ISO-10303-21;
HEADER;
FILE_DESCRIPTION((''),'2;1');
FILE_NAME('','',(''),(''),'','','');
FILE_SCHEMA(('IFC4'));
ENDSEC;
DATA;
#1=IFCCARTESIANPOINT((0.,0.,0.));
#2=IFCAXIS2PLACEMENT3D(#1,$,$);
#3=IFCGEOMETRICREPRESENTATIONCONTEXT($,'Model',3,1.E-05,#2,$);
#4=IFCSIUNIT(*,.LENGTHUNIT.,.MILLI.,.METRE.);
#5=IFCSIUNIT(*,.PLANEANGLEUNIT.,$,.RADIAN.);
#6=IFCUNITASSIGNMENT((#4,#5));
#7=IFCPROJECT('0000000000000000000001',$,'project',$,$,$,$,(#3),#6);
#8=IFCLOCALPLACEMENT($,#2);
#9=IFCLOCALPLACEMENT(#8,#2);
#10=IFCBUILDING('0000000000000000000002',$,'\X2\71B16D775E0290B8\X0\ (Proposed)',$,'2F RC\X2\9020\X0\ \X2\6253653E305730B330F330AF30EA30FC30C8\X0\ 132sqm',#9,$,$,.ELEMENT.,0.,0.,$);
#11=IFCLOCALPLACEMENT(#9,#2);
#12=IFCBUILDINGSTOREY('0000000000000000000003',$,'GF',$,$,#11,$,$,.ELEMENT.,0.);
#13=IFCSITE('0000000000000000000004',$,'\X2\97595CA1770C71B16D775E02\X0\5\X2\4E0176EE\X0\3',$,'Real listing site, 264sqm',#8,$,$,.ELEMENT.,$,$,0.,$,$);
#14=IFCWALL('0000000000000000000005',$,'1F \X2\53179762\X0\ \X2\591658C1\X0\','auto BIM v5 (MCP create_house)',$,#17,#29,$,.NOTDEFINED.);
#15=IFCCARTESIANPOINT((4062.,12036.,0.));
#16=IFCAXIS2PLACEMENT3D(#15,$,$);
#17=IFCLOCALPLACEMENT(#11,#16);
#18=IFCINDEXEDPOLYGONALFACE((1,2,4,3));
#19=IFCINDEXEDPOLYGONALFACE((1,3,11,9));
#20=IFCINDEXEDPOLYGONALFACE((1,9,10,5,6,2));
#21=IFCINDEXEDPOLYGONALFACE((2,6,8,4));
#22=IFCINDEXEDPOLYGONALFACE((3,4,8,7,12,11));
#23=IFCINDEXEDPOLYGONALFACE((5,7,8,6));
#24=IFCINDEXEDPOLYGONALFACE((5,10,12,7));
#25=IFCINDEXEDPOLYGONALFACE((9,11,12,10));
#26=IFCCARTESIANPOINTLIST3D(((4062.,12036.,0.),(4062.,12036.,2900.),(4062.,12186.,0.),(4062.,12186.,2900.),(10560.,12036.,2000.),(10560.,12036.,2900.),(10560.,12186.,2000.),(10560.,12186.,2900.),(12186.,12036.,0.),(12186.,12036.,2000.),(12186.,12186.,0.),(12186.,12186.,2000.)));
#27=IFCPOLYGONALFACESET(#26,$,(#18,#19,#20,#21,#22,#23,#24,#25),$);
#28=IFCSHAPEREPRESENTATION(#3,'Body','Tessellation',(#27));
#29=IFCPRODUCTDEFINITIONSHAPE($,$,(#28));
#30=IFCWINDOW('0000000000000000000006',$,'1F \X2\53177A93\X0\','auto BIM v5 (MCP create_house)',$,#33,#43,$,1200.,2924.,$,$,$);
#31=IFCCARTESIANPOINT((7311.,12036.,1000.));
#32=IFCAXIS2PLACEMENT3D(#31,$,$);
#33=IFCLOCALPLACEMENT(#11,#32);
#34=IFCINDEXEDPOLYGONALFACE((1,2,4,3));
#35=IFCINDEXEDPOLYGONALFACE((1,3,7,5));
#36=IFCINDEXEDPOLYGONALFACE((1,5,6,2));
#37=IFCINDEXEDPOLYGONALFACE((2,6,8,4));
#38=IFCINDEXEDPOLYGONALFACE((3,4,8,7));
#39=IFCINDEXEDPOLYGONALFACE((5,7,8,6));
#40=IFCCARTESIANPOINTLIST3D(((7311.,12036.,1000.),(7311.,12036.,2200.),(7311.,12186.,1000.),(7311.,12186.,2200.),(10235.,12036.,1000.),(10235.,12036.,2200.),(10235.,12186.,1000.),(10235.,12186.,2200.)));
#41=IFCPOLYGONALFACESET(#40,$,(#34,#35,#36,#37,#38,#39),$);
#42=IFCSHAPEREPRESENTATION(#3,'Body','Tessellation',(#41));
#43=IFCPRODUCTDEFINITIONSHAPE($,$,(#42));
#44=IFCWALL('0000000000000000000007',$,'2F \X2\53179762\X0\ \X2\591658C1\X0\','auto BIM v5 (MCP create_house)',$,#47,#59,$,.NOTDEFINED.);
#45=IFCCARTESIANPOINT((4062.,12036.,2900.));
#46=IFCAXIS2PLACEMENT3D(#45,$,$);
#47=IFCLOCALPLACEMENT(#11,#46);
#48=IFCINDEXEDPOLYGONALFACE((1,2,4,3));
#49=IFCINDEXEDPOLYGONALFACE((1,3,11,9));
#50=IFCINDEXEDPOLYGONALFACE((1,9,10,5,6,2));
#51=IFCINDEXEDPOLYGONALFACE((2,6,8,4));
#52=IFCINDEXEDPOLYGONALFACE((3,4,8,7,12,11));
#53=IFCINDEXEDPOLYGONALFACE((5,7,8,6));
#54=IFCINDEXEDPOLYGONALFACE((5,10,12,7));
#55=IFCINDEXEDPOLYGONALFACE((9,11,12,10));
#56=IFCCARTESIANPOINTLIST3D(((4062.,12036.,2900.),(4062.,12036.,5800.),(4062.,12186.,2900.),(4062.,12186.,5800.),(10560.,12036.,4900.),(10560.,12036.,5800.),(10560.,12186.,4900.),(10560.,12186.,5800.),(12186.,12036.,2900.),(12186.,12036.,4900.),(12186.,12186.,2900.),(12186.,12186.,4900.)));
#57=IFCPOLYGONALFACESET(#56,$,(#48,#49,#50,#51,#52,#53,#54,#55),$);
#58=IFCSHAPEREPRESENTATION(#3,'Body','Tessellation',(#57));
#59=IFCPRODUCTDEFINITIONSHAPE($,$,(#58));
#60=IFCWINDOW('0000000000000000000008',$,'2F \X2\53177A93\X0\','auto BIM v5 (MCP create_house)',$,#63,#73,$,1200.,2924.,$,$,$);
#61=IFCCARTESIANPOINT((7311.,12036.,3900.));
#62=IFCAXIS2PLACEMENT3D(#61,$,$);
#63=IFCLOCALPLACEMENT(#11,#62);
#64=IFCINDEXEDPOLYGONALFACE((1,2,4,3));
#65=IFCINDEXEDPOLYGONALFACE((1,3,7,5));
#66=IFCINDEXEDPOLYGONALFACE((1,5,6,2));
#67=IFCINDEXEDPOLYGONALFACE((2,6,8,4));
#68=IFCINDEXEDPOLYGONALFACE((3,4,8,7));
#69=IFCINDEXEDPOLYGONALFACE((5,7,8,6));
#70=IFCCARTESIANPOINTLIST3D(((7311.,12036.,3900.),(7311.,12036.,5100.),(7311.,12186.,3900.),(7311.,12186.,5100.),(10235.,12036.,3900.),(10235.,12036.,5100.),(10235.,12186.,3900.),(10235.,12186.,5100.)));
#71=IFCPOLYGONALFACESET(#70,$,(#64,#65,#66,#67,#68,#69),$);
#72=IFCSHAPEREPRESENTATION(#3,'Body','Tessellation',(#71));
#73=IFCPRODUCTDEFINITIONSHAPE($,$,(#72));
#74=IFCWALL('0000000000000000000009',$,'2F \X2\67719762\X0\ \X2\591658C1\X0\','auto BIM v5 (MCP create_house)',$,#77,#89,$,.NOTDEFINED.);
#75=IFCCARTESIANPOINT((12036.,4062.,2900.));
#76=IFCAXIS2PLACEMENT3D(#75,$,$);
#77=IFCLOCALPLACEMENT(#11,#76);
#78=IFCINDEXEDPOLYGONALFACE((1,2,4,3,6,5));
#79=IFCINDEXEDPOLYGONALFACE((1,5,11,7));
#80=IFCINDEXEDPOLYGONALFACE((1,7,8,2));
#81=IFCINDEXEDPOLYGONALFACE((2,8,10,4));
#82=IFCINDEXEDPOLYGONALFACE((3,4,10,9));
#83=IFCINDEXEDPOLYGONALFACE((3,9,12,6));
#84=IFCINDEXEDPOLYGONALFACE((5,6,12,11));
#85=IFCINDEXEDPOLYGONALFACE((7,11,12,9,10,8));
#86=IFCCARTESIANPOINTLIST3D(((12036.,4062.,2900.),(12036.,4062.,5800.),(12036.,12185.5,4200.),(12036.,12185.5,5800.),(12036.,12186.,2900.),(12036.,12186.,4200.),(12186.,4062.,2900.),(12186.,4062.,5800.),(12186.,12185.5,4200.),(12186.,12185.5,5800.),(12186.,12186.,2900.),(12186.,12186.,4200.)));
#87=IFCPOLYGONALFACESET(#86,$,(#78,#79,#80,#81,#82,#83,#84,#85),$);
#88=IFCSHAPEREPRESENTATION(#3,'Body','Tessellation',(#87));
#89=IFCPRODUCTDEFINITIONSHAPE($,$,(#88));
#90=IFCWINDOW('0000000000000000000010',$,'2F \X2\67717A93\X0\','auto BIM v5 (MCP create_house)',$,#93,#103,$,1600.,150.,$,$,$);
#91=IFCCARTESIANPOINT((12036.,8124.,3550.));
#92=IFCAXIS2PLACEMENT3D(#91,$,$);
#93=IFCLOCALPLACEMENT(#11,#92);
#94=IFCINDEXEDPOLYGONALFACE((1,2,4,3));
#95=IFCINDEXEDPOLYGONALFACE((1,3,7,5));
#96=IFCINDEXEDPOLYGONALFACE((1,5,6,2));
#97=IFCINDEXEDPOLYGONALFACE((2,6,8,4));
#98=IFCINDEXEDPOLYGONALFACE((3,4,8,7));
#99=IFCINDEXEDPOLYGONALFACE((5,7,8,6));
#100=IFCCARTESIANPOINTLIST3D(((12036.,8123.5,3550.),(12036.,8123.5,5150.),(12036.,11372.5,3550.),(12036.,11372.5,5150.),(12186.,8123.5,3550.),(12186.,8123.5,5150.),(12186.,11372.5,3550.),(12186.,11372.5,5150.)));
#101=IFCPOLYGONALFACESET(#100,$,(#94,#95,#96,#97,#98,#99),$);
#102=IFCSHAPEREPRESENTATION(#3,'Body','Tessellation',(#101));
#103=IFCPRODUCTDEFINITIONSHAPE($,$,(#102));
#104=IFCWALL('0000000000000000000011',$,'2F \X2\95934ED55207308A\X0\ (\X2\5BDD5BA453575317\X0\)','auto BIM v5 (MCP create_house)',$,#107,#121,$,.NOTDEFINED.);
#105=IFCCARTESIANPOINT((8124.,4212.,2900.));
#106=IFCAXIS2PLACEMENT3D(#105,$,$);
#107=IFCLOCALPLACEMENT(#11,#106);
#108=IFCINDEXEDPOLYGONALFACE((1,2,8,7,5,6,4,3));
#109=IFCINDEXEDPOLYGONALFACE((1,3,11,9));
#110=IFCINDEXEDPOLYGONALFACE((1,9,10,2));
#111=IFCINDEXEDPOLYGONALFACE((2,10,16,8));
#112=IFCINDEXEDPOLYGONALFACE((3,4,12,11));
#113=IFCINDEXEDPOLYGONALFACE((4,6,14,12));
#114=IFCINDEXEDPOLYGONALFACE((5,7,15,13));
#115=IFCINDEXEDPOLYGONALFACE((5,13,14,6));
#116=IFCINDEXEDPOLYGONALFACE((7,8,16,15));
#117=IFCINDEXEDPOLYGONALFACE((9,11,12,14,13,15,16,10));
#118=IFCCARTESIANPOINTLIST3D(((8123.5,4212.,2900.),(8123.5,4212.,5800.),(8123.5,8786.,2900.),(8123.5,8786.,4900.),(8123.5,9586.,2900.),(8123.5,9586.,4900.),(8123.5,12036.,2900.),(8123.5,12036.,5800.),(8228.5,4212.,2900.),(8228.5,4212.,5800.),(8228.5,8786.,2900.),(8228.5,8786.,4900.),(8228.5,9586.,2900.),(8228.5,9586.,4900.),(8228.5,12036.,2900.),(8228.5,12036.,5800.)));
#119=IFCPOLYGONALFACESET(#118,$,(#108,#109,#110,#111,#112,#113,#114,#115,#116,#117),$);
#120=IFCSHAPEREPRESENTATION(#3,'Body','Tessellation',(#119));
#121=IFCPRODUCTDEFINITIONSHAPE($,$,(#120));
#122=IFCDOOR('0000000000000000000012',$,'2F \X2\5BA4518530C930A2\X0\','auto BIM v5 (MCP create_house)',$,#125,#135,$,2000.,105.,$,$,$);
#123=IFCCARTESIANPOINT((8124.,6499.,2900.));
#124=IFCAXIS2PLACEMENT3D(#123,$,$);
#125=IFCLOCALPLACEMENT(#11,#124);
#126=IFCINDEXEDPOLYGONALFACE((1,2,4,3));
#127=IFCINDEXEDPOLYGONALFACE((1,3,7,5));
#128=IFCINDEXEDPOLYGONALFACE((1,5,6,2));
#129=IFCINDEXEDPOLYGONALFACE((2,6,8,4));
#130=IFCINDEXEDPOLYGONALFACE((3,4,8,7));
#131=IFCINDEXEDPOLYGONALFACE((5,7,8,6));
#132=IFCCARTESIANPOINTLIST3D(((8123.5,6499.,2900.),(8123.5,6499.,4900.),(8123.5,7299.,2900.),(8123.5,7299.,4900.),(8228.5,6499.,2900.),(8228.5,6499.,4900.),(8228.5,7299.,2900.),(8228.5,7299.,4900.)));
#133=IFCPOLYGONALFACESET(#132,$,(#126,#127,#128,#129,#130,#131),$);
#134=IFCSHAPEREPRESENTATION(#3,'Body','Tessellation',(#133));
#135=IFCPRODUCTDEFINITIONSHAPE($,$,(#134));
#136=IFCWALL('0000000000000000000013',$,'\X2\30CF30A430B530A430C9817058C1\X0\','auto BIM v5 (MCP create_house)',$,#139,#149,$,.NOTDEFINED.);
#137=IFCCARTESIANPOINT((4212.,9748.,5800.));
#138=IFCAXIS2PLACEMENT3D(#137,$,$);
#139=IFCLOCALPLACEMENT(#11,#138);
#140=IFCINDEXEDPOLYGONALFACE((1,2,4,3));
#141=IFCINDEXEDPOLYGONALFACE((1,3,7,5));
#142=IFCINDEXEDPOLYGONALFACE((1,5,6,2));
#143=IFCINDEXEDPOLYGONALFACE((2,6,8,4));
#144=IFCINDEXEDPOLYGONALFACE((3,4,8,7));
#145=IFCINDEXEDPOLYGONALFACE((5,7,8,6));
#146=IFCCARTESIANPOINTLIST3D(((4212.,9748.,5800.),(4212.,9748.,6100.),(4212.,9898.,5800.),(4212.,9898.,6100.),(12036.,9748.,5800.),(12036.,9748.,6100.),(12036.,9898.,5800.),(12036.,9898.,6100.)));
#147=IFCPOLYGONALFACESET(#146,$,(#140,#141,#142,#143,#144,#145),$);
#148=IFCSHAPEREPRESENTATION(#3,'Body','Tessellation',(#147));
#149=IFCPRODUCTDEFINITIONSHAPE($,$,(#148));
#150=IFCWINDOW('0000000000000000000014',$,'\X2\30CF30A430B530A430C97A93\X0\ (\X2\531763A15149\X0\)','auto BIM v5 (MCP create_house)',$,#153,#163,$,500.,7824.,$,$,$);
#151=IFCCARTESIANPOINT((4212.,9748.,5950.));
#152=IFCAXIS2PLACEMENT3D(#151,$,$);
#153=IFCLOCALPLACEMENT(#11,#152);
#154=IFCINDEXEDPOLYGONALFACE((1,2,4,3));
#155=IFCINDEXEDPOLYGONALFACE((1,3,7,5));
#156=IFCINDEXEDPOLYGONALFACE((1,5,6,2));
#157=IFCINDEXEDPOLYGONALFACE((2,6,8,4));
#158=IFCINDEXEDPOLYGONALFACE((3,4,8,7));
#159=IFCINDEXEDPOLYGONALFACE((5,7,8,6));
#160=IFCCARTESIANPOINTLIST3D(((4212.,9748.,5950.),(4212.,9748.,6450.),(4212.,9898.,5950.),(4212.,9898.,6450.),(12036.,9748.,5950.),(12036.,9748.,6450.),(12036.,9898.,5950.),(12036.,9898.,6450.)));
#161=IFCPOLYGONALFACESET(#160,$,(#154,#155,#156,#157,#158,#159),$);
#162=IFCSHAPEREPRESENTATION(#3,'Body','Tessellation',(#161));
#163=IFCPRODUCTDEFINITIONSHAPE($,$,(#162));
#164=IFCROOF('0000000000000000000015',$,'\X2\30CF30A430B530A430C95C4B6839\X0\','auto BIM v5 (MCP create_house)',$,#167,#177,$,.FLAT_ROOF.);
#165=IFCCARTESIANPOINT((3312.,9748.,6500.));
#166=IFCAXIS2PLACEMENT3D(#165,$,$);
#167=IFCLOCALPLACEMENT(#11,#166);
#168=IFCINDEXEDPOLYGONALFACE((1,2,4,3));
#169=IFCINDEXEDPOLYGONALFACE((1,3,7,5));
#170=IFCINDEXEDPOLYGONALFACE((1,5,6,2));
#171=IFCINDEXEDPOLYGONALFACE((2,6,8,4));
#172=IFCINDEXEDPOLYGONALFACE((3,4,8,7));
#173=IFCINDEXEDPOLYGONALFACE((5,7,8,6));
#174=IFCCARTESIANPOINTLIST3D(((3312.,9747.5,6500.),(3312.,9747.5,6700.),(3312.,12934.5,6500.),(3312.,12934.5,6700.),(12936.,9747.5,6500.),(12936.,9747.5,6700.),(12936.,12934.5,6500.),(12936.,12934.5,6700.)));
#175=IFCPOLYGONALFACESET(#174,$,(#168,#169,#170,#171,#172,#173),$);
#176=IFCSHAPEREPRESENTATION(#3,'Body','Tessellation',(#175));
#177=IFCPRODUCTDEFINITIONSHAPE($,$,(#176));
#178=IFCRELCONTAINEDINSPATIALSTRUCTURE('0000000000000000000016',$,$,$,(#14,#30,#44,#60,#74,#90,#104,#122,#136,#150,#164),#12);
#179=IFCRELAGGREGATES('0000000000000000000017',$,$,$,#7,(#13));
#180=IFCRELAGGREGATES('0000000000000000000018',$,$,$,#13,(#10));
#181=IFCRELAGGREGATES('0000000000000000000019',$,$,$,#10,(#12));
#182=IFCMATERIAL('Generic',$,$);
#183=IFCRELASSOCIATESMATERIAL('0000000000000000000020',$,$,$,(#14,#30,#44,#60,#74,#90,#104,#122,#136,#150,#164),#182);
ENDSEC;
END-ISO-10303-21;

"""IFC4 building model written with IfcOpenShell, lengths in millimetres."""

from ifc_helpers import new_model, si_unit, frame, frame_2d, origin, place, context, project, spatial, rectangle, extrude, material, element, fill, save


model = new_model("IFC4")

# Units and contexts
model_context = context("Model", 3, precision=1e-05, world=origin())
ifc_project = project(units=[si_unit("LENGTHUNIT", "METRE", prefix="MILLI"), si_unit("PLANEANGLEUNIT", "RADIAN")], contexts=[model_context])

# Site, building, storey
site_placement = place(None, origin())
site = spatial("IfcSite", under=ifc_project, at=site_placement, Name="静岡県熱海市5丁目3", ObjectType="Real listing site, 264sqm", CompositionType="ELEMENT", RefElevation=0.0)
building_placement = place(site_placement, origin())
building = spatial("IfcBuilding", under=site, at=building_placement, Name="熱海市邸 (Proposed)", ObjectType="2F RC造 打放しコンクリート 132sqm", CompositionType="ELEMENT", ElevationOfRefHeight=0.0, ElevationOfTerrain=0.0)
storey_placement = place(building_placement, origin())
storey = spatial("IfcBuildingStorey", under=building, at=storey_placement, Name="GF", CompositionType="ELEMENT", Elevation=0.0)

# Wall, opening, window
ifc_material = material(Name="Generic")
wall_1_placement = place(storey_placement, frame((4062.0, 12036.0, 0.0)))
wall_1 = element("IfcWall", 1, at=wall_1_placement, inside=storey, material=ifc_material, Name="1F 北面 外壁", Description="auto BIM v5 (MCP create_house)", PredefinedType="NOTDEFINED", context=model_context, shape_type="SweptSolid", body=[
    extrude(rectangle(XDim=8124.0, YDim=150.0, at=frame_2d((4062.0, 75.0))), frame((4062.0, 12036.0, 0.0)), (0.0, 0.0, 1.0), 2900.0),
])
opening_1_placement = place(storey_placement, frame((7311.0, 12036.0, 1000.0)))
opening_1 = element("IfcOpeningElement", 2, at=opening_1_placement, cuts=wall_1, PredefinedType="NOTDEFINED", context=model_context, shape_type="SweptSolid", body=[
    extrude(rectangle(XDim=2924.0, YDim=150.0, at=frame_2d((1462.0, 75.0))), frame((7311.0, 12036.0, 1000.0)), (0.0, 0.0, 1.0), 1200.0),
])
window_1_placement = place(storey_placement, frame((7311.0, 12036.0, 1000.0)))
window_1 = element("IfcWindow", 3, at=window_1_placement, inside=storey, material=ifc_material, Name="1F 北窓", Description="auto BIM v5 (MCP create_house)", OverallHeight=1200.0, OverallWidth=2924.0, context=model_context, shape_type="SweptSolid", body=[
    extrude(rectangle(XDim=2924.0, YDim=150.0, at=frame_2d((1462.0, 75.0))), frame((7311.0, 12036.0, 1000.0)), (0.0, 0.0, 1.0), 1200.0),
])
fill(opening_1, window_1)

# Walls, openings, windows
wall_2_placement = place(storey_placement, frame((4062.0, 12036.0, 2900.0)))
wall_2 = element("IfcWall", 4, at=wall_2_placement, inside=storey, material=ifc_material, Name="2F 北面 外壁", Description="auto BIM v5 (MCP create_house)", PredefinedType="NOTDEFINED", context=model_context, shape_type="SweptSolid", body=[
    extrude(rectangle(XDim=8124.0, YDim=150.0, at=frame_2d((4062.0, 75.0))), frame((4062.0, 12036.0, 2900.0)), (0.0, 0.0, 1.0), 2900.0),
])
opening_2_placement = place(storey_placement, frame((7311.0, 12036.0, 3900.0)))
opening_2 = element("IfcOpeningElement", 5, at=opening_2_placement, cuts=wall_2, PredefinedType="NOTDEFINED", context=model_context, shape_type="SweptSolid", body=[
    extrude(rectangle(XDim=2924.0, YDim=150.0, at=frame_2d((1462.0, 75.0))), frame((7311.0, 12036.0, 3900.0)), (0.0, 0.0, 1.0), 1200.0),
])
window_2_placement = place(storey_placement, frame((7311.0, 12036.0, 3900.0)))
window_2 = element("IfcWindow", 6, at=window_2_placement, inside=storey, material=ifc_material, Name="2F 北窓", Description="auto BIM v5 (MCP create_house)", OverallHeight=1200.0, OverallWidth=2924.0, context=model_context, shape_type="SweptSolid", body=[
    extrude(rectangle(XDim=2924.0, YDim=150.0, at=frame_2d((1462.0, 75.0))), frame((7311.0, 12036.0, 3900.0)), (0.0, 0.0, 1.0), 1200.0),
])
fill(opening_2, window_2)
wall_3_placement = place(storey_placement, frame((12036.0, 4062.0, 2900.0)))
wall_3 = element("IfcWall", 7, at=wall_3_placement, inside=storey, material=ifc_material, Name="2F 東面 外壁", Description="auto BIM v5 (MCP create_house)", PredefinedType="NOTDEFINED", context=model_context, shape_type="SweptSolid", body=[
    extrude(rectangle(XDim=150.0, YDim=8124.0, at=frame_2d((75.0, 4062.0))), frame((12036.0, 4062.0, 2900.0)), (0.0, 0.0, 1.0), 2900.0),
])
opening_3_placement = place(storey_placement, frame((12036.0, 8124.0, 3550.0)))
opening_3 = element("IfcOpeningElement", 8, at=opening_3_placement, cuts=wall_3, PredefinedType="NOTDEFINED", context=model_context, shape_type="SweptSolid", body=[
    extrude(rectangle(XDim=150.0, YDim=3249.0, at=frame_2d((75.0, 1624.0))), frame((12036.0, 8124.0, 3550.0)), (0.0, 0.0, 1.0), 1600.0),
])
window_3_placement = place(storey_placement, frame((12036.0, 8124.0, 3550.0)))
window_3 = element("IfcWindow", 9, at=window_3_placement, inside=storey, material=ifc_material, Name="2F 東窓", Description="auto BIM v5 (MCP create_house)", OverallHeight=1600.0, OverallWidth=150.0, context=model_context, shape_type="SweptSolid", body=[
    extrude(rectangle(XDim=150.0, YDim=3249.0, at=frame_2d((75.0, 1624.0))), frame((12036.0, 8124.0, 3550.0)), (0.0, 0.0, 1.0), 1600.0),
])
fill(opening_3, window_3)

# Wall, opening, door
wall_4_placement = place(storey_placement, frame((8124.0, 4212.0, 2900.0)))
wall_4 = element("IfcWall", 10, at=wall_4_placement, inside=storey, material=ifc_material, Name="2F 間仕切り (寝室南北)", Description="auto BIM v5 (MCP create_house)", PredefinedType="NOTDEFINED", context=model_context, shape_type="SweptSolid", body=[
    extrude(rectangle(XDim=105.0, YDim=7824.0, at=frame_2d((52.0, 3912.0))), frame((8124.0, 4212.0, 2900.0)), (0.0, 0.0, 1.0), 2900.0),
])
opening_4_placement = place(storey_placement, frame((8124.0, 6499.0, 2900.0)))
opening_4 = element("IfcOpeningElement", 11, at=opening_4_placement, cuts=wall_4, PredefinedType="NOTDEFINED", context=model_context, shape_type="SweptSolid", body=[
    extrude(rectangle(XDim=105.0, YDim=800.0, at=frame_2d((52.0, 400.0))), frame((8124.0, 6499.0, 2900.0)), (0.0, 0.0, 1.0), 2000.0),
])
door_placement = place(storey_placement, frame((8124.0, 6499.0, 2900.0)))
door = element("IfcDoor", 12, at=door_placement, inside=storey, material=ifc_material, Name="2F 室内ドア", Description="auto BIM v5 (MCP create_house)", OverallHeight=2000.0, OverallWidth=105.0, context=model_context, shape_type="SweptSolid", body=[
    extrude(rectangle(XDim=105.0, YDim=800.0, at=frame_2d((52.0, 400.0))), frame((8124.0, 6499.0, 2900.0)), (0.0, 0.0, 1.0), 2000.0),
])
fill(opening_4, door)

# Wall, opening, window
wall_5_placement = place(storey_placement, frame((4212.0, 9748.0, 5800.0)))
wall_5 = element("IfcWall", 13, at=wall_5_placement, inside=storey, material=ifc_material, Name="ハイサイド腰壁", Description="auto BIM v5 (MCP create_house)", PredefinedType="NOTDEFINED", context=model_context, shape_type="SweptSolid", body=[
    extrude(rectangle(XDim=7824.0, YDim=150.0, at=frame_2d((3912.0, 75.0))), frame((4212.0, 9748.0, 5800.0)), (0.0, 0.0, 1.0), 700.0),
])
opening_5_placement = place(storey_placement, frame((4212.0, 9748.0, 5950.0)))
opening_5 = element("IfcOpeningElement", 14, at=opening_5_placement, cuts=wall_5, PredefinedType="NOTDEFINED", context=model_context, shape_type="SweptSolid", body=[
    extrude(rectangle(XDim=7824.0, YDim=150.0, at=frame_2d((3912.0, 75.0))), frame((4212.0, 9748.0, 5950.0)), (0.0, 0.0, 1.0), 500.0),
])
window_4_placement = place(storey_placement, frame((4212.0, 9748.0, 5950.0)))
window_4 = element("IfcWindow", 15, at=window_4_placement, inside=storey, material=ifc_material, Name="ハイサイド窓 (北採光)", Description="auto BIM v5 (MCP create_house)", OverallHeight=500.0, OverallWidth=7824.0, context=model_context, shape_type="SweptSolid", body=[
    extrude(rectangle(XDim=7824.0, YDim=150.0, at=frame_2d((3912.0, 75.0))), frame((4212.0, 9748.0, 5950.0)), (0.0, 0.0, 1.0), 500.0),
])
fill(opening_5, window_4)

# Roof
roof_placement = place(storey_placement, frame((3312.0, 9748.0, 6500.0)))
element("IfcRoof", 16, at=roof_placement, inside=storey, material=ifc_material, Name="ハイサイド屋根", Description="auto BIM v5 (MCP create_house)", PredefinedType="FLAT_ROOF", context=model_context, shape_type="SweptSolid", body=[
    extrude(rectangle(XDim=9624.0, YDim=3187.0, at=frame_2d((4812.0, 1593.0))), frame((3312.0, 9748.0, 6500.0)), (0.0, 0.0, 1.0), 200.0),
])

save(model, "model.ifc")
